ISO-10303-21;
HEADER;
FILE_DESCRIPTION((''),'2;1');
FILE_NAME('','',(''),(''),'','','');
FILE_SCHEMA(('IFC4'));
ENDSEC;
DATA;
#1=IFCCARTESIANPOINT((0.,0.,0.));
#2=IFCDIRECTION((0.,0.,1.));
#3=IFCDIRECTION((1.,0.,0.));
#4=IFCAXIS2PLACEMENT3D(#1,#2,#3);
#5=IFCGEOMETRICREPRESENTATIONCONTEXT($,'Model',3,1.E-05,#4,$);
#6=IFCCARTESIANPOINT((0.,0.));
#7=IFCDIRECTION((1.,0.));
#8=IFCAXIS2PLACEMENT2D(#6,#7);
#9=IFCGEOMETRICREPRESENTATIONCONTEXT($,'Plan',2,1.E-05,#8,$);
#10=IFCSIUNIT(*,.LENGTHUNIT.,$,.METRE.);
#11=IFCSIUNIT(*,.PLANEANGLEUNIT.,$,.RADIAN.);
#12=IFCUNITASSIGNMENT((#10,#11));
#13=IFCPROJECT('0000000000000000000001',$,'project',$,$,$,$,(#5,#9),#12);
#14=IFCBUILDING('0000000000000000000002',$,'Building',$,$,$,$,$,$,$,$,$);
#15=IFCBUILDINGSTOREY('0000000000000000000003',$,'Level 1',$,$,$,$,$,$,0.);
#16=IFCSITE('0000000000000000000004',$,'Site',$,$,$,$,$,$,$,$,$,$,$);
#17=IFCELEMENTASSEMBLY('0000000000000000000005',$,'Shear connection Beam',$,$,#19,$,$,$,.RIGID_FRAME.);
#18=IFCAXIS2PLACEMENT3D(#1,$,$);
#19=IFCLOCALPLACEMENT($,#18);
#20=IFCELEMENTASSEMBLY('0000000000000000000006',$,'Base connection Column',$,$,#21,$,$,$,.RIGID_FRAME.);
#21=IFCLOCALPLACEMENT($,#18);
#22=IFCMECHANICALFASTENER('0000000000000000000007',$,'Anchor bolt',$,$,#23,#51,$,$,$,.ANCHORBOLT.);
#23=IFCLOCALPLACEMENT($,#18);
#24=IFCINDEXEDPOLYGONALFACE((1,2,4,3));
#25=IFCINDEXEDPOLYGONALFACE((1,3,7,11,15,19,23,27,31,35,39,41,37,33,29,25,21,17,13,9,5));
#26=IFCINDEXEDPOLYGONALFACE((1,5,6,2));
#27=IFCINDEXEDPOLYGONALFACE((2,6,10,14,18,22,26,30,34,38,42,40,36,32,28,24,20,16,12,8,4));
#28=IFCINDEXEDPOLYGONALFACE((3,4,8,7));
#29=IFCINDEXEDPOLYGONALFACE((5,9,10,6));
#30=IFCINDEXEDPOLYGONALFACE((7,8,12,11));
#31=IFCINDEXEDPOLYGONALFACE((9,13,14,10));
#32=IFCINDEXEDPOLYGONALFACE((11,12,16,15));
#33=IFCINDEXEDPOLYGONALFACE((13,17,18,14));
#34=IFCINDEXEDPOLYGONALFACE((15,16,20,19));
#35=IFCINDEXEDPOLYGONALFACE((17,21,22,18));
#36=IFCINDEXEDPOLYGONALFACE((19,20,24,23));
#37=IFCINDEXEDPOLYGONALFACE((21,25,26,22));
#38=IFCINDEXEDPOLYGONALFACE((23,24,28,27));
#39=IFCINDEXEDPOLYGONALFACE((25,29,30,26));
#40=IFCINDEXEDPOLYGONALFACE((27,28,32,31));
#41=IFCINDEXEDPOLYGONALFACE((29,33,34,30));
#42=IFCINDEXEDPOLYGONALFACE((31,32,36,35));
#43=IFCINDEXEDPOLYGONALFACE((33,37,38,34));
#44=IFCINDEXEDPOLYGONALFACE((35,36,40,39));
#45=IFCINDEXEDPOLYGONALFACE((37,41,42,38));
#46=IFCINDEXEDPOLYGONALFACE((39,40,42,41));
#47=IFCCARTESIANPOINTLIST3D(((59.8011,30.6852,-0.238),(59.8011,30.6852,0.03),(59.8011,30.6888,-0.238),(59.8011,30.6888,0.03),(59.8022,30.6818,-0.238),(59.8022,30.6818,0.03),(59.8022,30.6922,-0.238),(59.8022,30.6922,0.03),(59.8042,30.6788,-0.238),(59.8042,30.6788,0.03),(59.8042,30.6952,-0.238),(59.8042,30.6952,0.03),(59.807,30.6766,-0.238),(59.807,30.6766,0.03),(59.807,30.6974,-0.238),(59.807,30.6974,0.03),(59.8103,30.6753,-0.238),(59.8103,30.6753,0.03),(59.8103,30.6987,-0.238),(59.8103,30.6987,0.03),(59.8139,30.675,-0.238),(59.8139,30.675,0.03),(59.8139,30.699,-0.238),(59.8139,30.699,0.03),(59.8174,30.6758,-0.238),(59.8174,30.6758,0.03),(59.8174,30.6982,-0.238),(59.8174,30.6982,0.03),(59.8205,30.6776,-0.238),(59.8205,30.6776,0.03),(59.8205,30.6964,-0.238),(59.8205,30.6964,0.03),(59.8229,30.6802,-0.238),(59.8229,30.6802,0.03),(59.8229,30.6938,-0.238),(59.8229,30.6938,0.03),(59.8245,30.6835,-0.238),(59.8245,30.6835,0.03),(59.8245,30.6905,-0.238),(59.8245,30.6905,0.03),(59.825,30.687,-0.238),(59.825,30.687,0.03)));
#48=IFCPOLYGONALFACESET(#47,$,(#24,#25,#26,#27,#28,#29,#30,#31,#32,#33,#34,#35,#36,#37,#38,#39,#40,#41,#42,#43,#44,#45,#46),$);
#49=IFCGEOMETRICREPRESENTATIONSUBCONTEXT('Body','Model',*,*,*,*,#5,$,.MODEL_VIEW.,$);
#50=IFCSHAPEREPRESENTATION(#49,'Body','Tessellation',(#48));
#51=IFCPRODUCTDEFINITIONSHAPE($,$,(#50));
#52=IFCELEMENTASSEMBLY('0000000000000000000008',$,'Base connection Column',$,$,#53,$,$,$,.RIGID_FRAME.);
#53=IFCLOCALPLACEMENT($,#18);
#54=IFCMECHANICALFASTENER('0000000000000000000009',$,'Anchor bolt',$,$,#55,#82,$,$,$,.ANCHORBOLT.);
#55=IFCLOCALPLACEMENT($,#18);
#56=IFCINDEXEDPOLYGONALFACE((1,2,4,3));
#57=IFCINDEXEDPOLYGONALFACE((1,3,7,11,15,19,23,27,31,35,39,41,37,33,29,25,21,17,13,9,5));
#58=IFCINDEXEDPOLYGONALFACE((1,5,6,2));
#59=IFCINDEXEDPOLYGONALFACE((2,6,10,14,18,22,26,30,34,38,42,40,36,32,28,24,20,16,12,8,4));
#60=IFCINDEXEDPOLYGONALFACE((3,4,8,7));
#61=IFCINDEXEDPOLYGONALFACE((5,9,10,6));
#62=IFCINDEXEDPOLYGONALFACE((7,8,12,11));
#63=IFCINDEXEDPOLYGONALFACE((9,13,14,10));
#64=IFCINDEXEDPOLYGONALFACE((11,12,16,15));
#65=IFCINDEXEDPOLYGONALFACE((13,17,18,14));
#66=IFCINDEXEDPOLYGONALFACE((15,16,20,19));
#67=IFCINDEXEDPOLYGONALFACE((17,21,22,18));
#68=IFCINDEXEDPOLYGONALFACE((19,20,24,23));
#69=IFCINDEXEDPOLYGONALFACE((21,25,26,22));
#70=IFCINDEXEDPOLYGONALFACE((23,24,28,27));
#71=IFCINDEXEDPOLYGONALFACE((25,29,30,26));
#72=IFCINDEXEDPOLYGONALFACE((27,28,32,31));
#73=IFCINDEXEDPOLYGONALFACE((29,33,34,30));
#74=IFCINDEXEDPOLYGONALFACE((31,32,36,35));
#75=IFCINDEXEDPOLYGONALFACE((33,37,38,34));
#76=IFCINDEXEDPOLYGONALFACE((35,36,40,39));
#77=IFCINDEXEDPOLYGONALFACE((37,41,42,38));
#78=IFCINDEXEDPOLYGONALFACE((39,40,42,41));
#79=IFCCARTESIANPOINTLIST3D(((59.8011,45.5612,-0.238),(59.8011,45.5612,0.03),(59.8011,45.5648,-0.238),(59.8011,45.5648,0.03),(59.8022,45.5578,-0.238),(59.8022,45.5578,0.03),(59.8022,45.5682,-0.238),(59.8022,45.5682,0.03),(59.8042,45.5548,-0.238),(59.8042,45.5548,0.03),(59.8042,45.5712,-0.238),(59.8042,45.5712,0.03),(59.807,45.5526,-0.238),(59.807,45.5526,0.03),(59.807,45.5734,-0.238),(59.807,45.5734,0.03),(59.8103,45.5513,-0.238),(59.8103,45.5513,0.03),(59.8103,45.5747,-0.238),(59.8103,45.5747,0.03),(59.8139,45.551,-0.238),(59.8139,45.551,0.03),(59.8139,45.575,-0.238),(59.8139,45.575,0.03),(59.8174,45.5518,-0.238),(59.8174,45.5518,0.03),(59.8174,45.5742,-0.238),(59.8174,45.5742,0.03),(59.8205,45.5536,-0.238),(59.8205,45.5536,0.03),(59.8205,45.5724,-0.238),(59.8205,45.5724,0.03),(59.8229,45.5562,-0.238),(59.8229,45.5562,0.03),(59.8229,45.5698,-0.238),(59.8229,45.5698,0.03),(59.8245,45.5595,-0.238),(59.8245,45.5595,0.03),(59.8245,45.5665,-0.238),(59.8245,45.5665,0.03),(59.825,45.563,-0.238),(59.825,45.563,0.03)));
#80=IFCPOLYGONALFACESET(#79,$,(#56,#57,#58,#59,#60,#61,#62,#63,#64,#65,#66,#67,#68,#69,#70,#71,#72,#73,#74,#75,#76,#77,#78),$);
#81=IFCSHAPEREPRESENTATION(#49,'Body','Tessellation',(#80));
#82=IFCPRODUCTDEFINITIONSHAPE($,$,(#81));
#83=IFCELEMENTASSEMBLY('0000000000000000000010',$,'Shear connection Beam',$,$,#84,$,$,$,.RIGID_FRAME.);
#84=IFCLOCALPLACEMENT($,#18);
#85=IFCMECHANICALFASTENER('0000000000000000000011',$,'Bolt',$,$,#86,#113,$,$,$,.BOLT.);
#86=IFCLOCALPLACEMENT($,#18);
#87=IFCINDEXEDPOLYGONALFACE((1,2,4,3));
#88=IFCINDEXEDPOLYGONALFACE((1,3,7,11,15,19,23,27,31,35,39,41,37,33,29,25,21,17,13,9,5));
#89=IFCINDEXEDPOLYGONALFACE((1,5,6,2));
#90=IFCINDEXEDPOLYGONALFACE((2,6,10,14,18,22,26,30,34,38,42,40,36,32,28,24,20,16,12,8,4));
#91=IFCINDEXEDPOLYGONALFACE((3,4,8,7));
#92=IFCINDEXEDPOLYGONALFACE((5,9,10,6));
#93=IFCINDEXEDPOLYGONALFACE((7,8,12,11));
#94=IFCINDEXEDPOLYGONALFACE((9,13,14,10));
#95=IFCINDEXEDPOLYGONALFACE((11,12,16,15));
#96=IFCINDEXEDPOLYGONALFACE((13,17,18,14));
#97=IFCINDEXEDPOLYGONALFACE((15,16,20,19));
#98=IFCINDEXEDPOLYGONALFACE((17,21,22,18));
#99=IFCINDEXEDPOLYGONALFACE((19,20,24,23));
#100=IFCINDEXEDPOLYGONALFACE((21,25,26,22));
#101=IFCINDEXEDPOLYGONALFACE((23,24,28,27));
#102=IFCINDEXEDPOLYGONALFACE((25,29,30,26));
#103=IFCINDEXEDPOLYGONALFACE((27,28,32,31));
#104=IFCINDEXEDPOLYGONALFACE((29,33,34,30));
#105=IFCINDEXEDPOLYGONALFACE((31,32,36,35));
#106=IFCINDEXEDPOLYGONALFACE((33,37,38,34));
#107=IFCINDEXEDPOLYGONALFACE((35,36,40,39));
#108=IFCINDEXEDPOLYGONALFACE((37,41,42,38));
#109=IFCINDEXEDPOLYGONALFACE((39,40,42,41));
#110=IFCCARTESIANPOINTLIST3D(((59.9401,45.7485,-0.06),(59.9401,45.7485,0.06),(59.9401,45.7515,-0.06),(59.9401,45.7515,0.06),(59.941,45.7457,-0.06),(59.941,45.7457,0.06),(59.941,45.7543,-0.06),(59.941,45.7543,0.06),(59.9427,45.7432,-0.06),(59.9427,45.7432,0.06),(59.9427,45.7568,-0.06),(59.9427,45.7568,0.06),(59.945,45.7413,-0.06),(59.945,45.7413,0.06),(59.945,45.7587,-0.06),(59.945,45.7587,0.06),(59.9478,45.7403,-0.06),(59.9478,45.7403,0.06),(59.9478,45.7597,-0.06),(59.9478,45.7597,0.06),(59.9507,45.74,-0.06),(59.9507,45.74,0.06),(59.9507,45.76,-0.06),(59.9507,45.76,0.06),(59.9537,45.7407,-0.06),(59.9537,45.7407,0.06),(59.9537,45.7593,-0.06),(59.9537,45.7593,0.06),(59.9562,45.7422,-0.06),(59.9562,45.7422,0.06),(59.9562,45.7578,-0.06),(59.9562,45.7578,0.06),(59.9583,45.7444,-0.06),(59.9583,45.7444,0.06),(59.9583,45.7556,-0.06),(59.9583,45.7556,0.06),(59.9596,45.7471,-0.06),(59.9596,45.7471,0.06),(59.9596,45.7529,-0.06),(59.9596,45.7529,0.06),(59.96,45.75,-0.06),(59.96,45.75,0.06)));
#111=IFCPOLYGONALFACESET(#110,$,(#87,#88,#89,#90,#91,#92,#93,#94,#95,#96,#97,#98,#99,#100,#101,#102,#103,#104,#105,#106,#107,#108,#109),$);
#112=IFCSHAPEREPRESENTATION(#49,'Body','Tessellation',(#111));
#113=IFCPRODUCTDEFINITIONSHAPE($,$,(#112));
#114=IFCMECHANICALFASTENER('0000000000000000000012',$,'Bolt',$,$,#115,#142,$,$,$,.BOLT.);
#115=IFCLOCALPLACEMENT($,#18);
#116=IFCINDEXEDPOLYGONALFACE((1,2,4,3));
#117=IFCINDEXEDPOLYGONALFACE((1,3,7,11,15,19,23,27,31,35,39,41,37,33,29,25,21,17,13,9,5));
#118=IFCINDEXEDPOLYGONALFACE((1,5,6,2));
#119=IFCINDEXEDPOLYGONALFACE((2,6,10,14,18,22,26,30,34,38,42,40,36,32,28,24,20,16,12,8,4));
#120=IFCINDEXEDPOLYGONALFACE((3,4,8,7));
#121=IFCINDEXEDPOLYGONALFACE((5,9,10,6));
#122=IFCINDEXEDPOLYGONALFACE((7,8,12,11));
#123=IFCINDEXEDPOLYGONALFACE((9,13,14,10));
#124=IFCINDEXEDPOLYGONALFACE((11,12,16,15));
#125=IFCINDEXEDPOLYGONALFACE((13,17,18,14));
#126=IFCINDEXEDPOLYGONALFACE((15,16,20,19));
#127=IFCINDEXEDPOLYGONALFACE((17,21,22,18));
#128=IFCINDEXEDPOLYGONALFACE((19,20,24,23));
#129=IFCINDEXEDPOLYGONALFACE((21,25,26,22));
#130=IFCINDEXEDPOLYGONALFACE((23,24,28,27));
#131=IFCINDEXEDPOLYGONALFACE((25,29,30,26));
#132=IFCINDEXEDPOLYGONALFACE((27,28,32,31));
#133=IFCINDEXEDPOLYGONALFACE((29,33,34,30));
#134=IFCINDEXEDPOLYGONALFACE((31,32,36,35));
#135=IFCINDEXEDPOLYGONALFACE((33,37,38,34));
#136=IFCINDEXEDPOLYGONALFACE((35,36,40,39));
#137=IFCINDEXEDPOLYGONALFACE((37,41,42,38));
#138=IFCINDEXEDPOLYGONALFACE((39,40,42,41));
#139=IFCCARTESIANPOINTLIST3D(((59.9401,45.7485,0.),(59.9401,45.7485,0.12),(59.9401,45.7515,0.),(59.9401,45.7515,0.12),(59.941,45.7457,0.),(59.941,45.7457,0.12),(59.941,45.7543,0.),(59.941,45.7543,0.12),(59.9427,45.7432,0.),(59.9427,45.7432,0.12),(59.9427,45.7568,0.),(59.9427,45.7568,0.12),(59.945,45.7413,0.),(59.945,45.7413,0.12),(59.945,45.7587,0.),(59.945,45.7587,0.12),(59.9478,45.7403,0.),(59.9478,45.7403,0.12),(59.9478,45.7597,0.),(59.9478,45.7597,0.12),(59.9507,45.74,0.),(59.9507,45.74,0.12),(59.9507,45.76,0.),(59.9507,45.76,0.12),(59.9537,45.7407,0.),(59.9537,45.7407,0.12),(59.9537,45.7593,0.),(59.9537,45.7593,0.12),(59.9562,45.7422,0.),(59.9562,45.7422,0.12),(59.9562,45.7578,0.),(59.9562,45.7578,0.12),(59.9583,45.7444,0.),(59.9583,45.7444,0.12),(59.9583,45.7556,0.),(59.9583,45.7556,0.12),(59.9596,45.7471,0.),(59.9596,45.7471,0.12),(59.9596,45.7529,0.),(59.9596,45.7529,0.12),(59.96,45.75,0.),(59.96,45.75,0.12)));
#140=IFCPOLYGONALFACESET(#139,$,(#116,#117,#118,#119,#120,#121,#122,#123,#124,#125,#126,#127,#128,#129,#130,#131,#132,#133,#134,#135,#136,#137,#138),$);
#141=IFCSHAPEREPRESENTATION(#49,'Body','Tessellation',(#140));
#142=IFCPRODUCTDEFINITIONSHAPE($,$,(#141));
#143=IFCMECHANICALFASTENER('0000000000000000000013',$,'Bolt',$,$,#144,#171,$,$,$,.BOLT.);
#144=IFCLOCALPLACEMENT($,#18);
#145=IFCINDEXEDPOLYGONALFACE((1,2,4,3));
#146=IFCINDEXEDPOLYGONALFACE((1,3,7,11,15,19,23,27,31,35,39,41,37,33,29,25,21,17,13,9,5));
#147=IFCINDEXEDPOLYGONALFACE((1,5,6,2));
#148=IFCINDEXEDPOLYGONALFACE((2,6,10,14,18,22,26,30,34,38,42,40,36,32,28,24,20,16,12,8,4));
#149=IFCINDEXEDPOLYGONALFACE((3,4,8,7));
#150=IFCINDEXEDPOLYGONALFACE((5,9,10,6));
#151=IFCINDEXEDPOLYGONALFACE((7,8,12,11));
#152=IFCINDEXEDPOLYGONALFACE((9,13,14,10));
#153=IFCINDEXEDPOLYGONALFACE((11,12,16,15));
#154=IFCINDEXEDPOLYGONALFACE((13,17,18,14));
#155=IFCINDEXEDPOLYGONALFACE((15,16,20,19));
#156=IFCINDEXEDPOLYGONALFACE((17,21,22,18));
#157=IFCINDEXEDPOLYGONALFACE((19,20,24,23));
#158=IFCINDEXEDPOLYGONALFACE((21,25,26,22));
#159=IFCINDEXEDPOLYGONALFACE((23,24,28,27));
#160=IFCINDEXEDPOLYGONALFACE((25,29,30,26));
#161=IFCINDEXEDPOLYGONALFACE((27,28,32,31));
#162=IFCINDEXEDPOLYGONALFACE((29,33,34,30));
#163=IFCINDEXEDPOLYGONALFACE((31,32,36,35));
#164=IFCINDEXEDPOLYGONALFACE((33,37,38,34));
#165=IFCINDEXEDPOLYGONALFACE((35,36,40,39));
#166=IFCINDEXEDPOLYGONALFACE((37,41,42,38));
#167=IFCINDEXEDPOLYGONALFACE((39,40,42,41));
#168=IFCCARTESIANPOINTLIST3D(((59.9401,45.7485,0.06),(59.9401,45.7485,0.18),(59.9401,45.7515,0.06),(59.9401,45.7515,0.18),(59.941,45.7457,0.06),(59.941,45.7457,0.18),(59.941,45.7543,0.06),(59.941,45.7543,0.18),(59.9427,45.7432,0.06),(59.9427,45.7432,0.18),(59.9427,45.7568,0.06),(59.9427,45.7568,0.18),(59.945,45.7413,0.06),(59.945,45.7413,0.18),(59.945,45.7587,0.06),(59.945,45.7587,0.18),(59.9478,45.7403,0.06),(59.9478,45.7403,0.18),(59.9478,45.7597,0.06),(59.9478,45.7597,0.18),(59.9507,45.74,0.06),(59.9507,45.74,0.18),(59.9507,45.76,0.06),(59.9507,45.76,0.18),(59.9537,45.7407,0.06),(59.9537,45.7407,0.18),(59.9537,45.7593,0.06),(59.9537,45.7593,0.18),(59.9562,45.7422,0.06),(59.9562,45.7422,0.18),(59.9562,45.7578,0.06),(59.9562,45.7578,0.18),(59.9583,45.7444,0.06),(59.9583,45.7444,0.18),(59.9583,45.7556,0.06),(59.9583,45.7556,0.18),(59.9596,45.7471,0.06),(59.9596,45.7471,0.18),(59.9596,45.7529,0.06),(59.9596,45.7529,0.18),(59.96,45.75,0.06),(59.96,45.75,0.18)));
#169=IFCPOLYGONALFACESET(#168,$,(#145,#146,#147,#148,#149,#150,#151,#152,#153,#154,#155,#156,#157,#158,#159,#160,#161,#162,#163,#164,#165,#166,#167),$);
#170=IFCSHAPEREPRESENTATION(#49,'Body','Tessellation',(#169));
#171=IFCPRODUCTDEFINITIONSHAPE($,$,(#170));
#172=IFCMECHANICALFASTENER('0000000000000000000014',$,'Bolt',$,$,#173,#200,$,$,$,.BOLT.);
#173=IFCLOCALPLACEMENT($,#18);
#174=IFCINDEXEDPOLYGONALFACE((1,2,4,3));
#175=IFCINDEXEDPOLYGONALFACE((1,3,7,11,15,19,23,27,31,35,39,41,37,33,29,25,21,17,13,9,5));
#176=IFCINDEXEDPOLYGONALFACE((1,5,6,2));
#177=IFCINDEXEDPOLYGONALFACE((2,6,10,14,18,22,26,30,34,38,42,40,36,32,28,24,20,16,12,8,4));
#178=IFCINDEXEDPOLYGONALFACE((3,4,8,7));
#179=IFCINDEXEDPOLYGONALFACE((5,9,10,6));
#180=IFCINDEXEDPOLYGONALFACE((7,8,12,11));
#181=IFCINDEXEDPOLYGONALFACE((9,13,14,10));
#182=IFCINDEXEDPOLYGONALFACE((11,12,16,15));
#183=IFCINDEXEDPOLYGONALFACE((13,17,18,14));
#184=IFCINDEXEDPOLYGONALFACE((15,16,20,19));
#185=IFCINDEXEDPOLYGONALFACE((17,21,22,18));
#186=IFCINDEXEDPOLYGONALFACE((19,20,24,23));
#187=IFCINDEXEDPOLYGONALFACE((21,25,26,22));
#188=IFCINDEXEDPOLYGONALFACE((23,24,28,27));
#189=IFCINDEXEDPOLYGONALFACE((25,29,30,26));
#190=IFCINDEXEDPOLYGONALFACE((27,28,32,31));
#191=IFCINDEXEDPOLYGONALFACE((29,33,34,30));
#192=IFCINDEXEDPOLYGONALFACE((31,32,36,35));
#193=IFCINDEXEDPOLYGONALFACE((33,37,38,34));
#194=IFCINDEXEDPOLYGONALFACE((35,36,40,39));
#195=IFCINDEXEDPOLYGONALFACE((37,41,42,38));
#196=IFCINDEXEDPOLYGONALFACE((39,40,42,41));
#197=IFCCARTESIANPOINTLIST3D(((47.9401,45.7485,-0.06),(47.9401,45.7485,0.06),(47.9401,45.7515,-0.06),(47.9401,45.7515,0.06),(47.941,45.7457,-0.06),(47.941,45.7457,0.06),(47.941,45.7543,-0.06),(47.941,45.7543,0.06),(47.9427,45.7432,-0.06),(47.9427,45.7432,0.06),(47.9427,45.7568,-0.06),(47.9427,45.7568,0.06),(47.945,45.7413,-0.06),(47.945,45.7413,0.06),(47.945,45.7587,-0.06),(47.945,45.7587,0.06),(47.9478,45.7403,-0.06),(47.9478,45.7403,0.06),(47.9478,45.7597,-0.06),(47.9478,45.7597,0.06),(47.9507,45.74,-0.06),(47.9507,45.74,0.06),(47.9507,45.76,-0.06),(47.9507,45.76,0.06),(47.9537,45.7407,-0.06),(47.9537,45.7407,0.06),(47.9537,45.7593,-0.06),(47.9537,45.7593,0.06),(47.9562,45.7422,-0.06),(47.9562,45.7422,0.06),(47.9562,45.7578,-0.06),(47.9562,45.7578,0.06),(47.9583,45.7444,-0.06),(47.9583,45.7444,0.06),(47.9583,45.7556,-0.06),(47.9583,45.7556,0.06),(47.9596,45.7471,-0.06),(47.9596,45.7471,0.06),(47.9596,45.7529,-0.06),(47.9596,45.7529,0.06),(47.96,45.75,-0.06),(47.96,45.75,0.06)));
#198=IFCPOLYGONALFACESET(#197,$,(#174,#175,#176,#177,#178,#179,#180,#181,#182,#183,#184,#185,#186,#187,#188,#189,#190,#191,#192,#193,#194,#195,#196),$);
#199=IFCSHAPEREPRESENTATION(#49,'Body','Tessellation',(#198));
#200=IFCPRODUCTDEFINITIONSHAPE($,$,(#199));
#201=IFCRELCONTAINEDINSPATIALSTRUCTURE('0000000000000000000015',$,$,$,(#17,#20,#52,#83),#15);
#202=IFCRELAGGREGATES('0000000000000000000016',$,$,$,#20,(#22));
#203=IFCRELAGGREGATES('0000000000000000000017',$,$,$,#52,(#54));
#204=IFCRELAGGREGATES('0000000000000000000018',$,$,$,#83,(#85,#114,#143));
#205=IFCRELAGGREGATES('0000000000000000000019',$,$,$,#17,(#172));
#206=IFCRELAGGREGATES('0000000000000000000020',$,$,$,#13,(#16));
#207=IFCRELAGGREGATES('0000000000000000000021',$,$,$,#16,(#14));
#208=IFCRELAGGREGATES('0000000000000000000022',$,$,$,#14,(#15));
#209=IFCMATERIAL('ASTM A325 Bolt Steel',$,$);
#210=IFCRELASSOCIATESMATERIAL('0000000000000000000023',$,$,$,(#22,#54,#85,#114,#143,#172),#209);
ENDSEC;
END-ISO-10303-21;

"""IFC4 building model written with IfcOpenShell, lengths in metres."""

from ifc_helpers import new_model, si_unit, frame, origin_with_axes, origin_2d, origin_2d_with_axis, place, context, subcontext, project, spatial, circle, extrude, material, element, aggregate, save


model = new_model("IFC4")

# Units and contexts
model_context = context("Model", 3, precision=1e-05, world=origin_with_axes())
plan_context = context("Plan", 2, precision=1e-05, world=origin_2d_with_axis())
body_context = subcontext(model_context, "Body", "Model", "MODEL_VIEW")
ifc_project = project(units=[si_unit("LENGTHUNIT", "METRE"), si_unit("PLANEANGLEUNIT", "RADIAN")], contexts=[model_context, plan_context])

# Site, building, storey
site = spatial("IfcSite", under=ifc_project, Name="Site")
building = spatial("IfcBuilding", under=site, Name="Building")
storey = spatial("IfcBuildingStorey", under=building, Name="Level 1", Elevation=0.0)

# Element assembly
assembly_1 = element("IfcElementAssembly", 1, inside=storey, Name="Shear connection Beam", PredefinedType="RIGID_FRAME")

# Shared definitions
ifc_material_1 = material(Name="ASTM A325 Bolt Steel")

# Element assemblies, mechanical fasteners
assembly_2 = element("IfcElementAssembly", 2, inside=storey, Name="Base connection Column", PredefinedType="RIGID_FRAME")
mechanical_fastener_1_placement = place(None, frame((59.813, 30.687, -0.238), z_axis=(0.0, 0.0, 1.0), x_axis=(1.0, 0.0, 0.0)))
mechanical_fastener_1 = element("IfcMechanicalFastener", 3, at=mechanical_fastener_1_placement, material=ifc_material_1, Name="Anchor bolt", PredefinedType="ANCHORBOLT", context=body_context, shape_type="SweptSolid", body=[
    extrude(circle(Radius=0.012, at=origin_2d()), origin_with_axes(), (0.0, 0.0, 1.0), 0.268),
])
aggregate(assembly_2, [mechanical_fastener_1])
assembly_3 = element("IfcElementAssembly", 4, inside=storey, Name="Base connection Column", PredefinedType="RIGID_FRAME")
mechanical_fastener_2_placement = place(None, frame((59.813, 45.563, -0.238), z_axis=(0.0, 0.0, 1.0), x_axis=(1.0, 0.0, 0.0)))
mechanical_fastener_2 = element("IfcMechanicalFastener", 5, at=mechanical_fastener_2_placement, material=ifc_material_1, Name="Anchor bolt", PredefinedType="ANCHORBOLT", context=body_context, shape_type="SweptSolid", body=[
    extrude(circle(Radius=0.012, at=origin_2d()), origin_with_axes(), (0.0, 0.0, 1.0), 0.268),
])
aggregate(assembly_3, [mechanical_fastener_2])

# Element assembly, mechanical fasteners
assembly_4 = element("IfcElementAssembly", 6, inside=storey, Name="Shear connection Beam", PredefinedType="RIGID_FRAME")
mechanical_fastener_3_placement = place(None, frame((59.95, 45.75, -0.06), z_axis=(0.0, 0.0, 1.0), x_axis=(1.0, 0.0, 0.0)))
mechanical_fastener_3 = element("IfcMechanicalFastener", 7, at=mechanical_fastener_3_placement, material=ifc_material_1, Name="Bolt", PredefinedType="BOLT", context=body_context, shape_type="SweptSolid", body=[
    extrude(circle(Radius=0.01, at=origin_2d()), origin_with_axes(), (0.0, 0.0, 1.0), 0.12),
])
mechanical_fastener_4_placement = place(None, frame((59.95, 45.75, 0.0), z_axis=(0.0, 0.0, 1.0), x_axis=(1.0, 0.0, 0.0)))
mechanical_fastener_4 = element("IfcMechanicalFastener", 8, at=mechanical_fastener_4_placement, material=ifc_material_1, Name="Bolt", PredefinedType="BOLT", context=body_context, shape_type="SweptSolid", body=[
    extrude(circle(Radius=0.01, at=origin_2d()), origin_with_axes(), (0.0, 0.0, 1.0), 0.12),
])
mechanical_fastener_5_placement = place(None, frame((59.95, 45.75, 0.06), z_axis=(0.0, 0.0, 1.0), x_axis=(1.0, 0.0, 0.0)))
mechanical_fastener_5 = element("IfcMechanicalFastener", 9, at=mechanical_fastener_5_placement, material=ifc_material_1, Name="Bolt", PredefinedType="BOLT", context=body_context, shape_type="SweptSolid", body=[
    extrude(circle(Radius=0.01, at=origin_2d()), origin_with_axes(), (0.0, 0.0, 1.0), 0.12),
])
aggregate(assembly_4, [mechanical_fastener_3, mechanical_fastener_4, mechanical_fastener_5])

# Mechanical fastener
mechanical_fastener_6_placement = place(None, frame((47.95, 45.75, -0.06), z_axis=(0.0, 0.0, 1.0), x_axis=(1.0, 0.0, 0.0)))
mechanical_fastener_6 = element("IfcMechanicalFastener", 10, at=mechanical_fastener_6_placement, material=ifc_material_1, Name="Bolt", PredefinedType="BOLT", context=body_context, shape_type="SweptSolid", body=[
    extrude(circle(Radius=0.01, at=origin_2d()), origin_with_axes(), (0.0, 0.0, 1.0), 0.12),
])
aggregate(assembly_1, [mechanical_fastener_6])

save(model, "model.ifc")
